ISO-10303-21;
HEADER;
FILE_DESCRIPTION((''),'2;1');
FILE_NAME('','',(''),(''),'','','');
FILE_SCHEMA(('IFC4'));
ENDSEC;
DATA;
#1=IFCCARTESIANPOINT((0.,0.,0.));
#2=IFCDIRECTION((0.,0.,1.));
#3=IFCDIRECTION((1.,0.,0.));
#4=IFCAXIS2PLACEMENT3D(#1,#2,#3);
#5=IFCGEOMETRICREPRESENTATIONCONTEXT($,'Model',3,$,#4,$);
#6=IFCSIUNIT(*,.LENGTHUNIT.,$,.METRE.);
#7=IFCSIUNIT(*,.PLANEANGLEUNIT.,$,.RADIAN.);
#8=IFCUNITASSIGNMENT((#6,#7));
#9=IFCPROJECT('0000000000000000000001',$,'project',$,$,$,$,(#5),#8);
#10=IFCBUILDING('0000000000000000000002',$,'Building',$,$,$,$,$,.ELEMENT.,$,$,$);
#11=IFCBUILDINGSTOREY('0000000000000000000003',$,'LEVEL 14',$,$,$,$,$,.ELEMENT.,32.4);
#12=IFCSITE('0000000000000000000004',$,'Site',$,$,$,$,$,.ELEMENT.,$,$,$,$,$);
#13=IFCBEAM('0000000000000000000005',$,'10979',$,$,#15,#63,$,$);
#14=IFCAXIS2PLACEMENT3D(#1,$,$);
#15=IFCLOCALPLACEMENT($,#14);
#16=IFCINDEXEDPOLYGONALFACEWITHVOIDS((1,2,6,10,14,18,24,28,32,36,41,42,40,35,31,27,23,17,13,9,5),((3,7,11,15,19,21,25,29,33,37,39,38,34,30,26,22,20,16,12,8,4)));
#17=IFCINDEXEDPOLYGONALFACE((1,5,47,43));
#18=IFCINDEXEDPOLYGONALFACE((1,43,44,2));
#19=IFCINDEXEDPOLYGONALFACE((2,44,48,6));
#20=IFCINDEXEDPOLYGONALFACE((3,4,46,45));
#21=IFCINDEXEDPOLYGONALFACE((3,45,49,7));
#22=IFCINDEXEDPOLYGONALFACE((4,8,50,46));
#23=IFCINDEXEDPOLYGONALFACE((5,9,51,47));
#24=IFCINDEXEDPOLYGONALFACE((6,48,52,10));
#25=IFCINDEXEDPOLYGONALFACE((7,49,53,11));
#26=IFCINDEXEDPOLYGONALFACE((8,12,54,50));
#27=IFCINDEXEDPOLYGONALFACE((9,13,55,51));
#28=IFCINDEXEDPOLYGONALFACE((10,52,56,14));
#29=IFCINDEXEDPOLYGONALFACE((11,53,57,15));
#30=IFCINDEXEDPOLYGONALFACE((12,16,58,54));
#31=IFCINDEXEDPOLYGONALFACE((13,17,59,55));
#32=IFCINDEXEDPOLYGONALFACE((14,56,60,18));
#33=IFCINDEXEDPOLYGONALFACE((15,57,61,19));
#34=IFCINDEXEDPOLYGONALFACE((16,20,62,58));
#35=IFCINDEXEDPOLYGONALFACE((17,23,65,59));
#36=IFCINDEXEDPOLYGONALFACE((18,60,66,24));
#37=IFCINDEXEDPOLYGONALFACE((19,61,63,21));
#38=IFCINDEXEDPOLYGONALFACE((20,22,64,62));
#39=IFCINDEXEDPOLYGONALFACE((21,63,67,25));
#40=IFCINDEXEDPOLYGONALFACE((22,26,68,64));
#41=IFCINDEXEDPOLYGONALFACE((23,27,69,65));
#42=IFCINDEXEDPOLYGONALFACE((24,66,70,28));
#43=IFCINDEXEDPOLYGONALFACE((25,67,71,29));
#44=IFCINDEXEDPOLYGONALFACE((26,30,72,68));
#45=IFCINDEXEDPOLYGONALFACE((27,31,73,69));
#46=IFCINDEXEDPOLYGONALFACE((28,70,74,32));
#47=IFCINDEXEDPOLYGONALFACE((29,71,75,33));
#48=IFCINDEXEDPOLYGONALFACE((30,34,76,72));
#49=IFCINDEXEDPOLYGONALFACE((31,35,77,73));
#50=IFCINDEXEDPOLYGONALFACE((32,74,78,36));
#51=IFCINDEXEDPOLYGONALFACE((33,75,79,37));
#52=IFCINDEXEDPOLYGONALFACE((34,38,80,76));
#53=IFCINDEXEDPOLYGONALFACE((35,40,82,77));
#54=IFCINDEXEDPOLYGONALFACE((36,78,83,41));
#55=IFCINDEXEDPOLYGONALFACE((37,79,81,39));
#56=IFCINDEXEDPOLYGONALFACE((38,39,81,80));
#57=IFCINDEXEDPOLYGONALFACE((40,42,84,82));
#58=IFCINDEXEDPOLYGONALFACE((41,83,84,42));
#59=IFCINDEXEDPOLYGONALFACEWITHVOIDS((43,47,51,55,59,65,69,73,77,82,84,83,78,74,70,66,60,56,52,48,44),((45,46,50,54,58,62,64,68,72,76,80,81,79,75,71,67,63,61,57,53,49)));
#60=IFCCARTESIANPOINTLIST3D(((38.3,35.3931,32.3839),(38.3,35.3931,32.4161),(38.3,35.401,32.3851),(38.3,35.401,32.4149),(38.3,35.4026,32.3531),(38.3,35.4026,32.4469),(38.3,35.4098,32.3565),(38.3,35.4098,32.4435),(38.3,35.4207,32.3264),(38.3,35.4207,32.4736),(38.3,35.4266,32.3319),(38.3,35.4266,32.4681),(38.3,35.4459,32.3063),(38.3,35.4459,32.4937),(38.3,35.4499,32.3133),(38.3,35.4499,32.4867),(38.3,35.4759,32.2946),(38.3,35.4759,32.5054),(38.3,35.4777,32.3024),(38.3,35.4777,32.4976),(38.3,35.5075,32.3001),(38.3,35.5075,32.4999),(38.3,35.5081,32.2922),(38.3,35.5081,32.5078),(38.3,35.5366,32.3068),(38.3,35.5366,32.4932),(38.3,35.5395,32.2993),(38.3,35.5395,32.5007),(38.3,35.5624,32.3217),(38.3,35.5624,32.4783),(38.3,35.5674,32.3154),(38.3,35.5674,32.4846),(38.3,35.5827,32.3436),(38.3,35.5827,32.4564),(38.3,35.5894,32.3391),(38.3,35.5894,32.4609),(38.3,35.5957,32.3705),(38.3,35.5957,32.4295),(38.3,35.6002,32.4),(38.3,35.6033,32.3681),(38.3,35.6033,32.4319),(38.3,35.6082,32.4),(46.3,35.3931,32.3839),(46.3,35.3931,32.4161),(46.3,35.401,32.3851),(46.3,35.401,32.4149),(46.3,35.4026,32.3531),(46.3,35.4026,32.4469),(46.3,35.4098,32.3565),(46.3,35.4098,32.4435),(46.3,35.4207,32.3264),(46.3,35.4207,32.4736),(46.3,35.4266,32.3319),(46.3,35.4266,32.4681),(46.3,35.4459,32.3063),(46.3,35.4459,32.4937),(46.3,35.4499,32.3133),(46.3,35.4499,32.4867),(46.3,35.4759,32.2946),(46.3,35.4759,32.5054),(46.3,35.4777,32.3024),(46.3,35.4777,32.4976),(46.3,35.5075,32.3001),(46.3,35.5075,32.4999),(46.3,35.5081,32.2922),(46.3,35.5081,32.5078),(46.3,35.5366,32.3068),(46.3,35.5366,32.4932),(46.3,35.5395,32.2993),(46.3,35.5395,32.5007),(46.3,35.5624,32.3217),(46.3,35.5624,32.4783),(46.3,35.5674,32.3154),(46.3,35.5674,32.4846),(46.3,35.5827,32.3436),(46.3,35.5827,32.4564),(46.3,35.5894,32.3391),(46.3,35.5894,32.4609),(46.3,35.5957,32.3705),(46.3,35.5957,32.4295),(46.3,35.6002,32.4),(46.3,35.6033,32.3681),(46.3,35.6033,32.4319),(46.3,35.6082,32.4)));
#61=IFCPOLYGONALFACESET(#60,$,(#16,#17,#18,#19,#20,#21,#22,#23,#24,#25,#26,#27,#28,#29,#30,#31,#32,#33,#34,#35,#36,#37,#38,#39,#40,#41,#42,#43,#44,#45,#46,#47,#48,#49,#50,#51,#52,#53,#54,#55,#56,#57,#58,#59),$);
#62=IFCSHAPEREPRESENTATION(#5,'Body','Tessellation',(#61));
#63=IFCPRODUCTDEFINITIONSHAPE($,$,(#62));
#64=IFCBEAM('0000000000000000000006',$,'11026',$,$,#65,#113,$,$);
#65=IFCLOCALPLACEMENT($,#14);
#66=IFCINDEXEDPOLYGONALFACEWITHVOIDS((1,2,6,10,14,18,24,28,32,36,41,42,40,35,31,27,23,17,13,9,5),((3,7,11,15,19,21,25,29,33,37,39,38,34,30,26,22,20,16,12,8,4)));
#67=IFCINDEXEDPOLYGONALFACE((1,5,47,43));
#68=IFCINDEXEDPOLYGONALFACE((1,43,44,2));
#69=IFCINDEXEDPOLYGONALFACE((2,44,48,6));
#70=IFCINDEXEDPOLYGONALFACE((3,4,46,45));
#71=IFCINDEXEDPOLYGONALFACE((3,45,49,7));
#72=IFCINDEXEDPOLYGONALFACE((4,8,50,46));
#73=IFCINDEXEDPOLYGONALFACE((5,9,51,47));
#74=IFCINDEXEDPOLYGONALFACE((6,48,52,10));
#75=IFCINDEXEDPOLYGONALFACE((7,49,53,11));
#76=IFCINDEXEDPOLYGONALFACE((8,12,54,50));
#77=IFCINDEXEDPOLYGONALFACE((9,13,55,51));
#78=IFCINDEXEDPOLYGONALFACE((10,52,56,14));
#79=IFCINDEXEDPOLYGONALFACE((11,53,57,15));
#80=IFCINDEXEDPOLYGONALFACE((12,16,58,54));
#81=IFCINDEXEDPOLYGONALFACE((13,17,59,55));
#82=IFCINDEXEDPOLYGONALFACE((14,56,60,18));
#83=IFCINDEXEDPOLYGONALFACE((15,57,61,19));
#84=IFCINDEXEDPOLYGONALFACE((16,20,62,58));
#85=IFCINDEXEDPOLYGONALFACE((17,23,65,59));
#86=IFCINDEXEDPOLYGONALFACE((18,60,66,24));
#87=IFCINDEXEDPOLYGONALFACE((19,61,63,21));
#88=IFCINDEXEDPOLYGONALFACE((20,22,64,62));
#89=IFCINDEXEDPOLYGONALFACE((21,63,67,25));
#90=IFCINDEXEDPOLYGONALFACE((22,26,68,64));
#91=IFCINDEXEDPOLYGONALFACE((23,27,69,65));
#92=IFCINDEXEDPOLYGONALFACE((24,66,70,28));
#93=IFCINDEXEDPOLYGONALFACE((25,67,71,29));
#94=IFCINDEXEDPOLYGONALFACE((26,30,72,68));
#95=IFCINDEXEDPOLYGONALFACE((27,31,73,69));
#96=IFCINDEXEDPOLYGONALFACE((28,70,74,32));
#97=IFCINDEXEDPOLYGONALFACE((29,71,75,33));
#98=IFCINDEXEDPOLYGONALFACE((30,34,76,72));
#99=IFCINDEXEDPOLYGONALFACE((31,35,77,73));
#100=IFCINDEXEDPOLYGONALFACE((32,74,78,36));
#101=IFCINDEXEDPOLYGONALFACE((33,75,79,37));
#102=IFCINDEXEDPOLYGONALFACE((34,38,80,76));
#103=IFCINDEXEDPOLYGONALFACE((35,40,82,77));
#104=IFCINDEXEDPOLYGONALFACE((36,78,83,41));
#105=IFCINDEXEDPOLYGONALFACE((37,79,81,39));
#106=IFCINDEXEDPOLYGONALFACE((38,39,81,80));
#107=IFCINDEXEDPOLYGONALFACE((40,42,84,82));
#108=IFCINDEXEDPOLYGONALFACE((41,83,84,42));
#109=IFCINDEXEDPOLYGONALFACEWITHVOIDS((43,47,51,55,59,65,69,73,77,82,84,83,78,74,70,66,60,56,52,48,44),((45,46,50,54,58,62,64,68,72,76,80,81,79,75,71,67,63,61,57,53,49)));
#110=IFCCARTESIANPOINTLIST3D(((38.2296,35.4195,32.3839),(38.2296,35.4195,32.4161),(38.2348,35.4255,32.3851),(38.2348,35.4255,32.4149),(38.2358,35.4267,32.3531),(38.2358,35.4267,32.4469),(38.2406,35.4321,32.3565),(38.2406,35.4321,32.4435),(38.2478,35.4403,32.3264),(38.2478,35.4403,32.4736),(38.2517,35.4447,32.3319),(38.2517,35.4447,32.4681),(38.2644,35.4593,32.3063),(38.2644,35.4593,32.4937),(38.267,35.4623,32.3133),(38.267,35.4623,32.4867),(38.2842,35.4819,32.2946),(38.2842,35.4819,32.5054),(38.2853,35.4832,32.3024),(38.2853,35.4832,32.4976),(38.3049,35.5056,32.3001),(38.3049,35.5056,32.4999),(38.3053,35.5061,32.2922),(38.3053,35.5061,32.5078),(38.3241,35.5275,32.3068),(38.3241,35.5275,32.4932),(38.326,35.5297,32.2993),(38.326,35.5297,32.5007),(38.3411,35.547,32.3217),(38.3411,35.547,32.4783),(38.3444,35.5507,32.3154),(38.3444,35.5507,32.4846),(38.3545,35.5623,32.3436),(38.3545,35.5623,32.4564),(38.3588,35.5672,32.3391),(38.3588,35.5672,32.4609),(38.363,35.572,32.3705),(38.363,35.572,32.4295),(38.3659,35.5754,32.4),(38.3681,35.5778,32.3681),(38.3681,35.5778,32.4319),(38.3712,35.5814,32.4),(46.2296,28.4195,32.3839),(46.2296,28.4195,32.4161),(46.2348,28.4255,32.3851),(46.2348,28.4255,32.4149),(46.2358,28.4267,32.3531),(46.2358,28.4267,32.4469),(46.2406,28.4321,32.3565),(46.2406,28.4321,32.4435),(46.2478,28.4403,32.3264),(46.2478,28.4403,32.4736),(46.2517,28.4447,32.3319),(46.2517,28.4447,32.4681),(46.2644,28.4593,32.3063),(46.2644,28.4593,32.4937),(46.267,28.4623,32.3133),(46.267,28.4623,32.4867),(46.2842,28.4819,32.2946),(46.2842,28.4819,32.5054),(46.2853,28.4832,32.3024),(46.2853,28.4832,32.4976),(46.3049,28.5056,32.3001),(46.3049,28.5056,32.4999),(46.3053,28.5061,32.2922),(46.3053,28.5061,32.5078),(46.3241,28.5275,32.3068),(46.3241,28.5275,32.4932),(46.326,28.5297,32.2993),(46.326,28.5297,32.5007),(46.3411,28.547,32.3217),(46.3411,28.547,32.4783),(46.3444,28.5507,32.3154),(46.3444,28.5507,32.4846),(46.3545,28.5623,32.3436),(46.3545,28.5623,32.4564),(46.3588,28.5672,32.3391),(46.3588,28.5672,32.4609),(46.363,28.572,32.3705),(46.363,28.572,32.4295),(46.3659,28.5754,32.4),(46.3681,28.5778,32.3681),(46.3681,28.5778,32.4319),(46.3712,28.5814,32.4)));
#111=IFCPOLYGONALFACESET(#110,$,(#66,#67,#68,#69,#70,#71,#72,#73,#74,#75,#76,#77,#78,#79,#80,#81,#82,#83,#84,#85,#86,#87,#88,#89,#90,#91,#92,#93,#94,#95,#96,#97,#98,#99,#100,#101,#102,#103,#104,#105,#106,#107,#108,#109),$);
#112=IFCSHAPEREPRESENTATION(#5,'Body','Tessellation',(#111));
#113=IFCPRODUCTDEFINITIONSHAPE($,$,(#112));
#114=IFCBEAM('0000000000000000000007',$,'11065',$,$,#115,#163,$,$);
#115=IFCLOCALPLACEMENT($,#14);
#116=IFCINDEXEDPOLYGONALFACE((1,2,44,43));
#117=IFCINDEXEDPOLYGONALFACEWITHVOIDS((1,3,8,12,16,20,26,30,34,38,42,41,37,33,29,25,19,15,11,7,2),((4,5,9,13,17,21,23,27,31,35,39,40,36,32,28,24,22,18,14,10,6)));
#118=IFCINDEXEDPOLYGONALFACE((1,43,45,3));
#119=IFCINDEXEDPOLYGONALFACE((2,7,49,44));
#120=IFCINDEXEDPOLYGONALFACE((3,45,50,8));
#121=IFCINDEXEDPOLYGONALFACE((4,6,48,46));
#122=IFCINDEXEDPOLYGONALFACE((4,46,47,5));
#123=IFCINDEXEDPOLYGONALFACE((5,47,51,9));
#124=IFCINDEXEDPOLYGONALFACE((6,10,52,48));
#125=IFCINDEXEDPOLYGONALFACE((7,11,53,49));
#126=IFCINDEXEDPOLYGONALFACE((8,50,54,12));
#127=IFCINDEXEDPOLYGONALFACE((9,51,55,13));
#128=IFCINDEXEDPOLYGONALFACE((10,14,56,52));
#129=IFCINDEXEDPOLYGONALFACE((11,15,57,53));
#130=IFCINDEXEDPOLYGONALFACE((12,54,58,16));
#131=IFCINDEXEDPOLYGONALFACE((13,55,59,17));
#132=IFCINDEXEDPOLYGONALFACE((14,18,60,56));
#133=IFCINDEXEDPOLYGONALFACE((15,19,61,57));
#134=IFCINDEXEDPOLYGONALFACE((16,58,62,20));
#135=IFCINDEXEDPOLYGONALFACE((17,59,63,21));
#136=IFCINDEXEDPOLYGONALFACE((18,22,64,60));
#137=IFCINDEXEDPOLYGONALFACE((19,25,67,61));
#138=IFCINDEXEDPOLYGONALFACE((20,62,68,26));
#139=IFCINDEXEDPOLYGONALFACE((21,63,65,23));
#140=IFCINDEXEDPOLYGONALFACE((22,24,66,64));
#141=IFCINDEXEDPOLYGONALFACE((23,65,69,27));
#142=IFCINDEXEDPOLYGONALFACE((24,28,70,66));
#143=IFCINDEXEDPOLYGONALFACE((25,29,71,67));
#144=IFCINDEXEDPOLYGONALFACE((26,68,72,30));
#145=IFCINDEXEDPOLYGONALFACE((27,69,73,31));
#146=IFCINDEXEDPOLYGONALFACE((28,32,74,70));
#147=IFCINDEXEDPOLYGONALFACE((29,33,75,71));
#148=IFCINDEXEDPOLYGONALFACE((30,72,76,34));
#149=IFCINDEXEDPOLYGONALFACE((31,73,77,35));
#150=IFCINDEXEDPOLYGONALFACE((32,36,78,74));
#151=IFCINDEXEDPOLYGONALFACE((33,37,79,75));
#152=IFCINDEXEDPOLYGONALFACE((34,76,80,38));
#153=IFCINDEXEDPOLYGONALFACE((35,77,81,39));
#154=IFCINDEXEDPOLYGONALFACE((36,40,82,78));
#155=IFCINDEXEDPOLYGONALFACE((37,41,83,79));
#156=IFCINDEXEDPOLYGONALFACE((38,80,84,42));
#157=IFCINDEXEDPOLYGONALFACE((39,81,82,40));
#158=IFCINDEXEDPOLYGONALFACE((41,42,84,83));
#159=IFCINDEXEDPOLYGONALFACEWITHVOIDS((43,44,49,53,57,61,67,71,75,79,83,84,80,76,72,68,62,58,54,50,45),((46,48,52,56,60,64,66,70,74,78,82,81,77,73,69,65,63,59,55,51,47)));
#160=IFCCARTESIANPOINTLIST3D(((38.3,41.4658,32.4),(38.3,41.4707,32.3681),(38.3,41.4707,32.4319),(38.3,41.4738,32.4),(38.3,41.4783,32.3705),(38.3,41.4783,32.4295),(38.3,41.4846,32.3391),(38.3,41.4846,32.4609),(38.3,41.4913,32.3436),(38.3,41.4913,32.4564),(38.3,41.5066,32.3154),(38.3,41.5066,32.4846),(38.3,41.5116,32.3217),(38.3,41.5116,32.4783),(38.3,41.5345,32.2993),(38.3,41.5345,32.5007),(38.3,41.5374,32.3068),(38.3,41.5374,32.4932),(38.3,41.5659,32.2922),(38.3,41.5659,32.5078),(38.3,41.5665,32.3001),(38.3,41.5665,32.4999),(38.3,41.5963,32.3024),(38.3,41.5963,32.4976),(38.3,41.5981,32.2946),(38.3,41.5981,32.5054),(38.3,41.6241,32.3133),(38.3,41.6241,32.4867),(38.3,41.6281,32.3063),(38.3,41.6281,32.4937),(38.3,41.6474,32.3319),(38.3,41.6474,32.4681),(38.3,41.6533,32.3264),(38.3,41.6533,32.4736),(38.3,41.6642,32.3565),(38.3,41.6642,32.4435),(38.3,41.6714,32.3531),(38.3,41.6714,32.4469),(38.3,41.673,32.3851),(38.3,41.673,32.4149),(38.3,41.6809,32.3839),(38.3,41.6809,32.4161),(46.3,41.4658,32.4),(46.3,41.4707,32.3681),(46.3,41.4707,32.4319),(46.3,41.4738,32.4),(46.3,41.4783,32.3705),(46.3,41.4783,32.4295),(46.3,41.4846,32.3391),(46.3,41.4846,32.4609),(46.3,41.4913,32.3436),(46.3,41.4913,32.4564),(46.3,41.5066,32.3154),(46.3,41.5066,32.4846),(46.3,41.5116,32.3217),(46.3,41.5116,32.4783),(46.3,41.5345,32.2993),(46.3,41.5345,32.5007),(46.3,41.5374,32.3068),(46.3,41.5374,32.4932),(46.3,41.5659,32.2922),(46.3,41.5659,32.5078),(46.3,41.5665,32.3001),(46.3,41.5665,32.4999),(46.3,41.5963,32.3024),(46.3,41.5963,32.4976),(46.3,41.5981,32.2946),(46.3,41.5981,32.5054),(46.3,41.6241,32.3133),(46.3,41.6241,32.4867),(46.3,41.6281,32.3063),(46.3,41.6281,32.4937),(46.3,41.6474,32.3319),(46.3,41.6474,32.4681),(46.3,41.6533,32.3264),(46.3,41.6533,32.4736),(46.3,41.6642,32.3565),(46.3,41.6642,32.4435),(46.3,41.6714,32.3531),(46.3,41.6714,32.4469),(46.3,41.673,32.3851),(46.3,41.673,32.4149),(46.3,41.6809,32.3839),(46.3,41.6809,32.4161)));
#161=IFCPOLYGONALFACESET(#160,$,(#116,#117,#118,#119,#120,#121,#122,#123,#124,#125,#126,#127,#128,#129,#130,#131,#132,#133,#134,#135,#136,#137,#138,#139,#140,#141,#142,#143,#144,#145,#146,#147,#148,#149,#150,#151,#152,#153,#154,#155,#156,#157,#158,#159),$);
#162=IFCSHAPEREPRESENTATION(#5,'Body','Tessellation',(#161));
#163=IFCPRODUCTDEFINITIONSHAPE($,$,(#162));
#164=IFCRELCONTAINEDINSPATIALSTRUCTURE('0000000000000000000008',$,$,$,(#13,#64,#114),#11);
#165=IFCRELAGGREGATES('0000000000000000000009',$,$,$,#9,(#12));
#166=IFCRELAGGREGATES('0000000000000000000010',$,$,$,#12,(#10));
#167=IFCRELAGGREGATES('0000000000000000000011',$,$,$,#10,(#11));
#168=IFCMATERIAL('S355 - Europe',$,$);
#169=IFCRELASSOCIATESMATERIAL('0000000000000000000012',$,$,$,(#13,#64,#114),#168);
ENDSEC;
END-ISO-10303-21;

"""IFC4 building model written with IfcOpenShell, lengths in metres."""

from ifc_helpers import new_model, si_unit, frame, origin_with_axes, origin_2d_with_axis, place, context, project, spatial, hollow_circle, extrude, material, material_profile, profile_set, profile_usage, element, save


model = new_model("IFC4")

# Units and contexts
model_context = context("Model", 3, world=origin_with_axes())
ifc_project = project(units=[si_unit("LENGTHUNIT", "METRE"), si_unit("PLANEANGLEUNIT", "RADIAN")], contexts=[model_context])

# Site, building, storey
site = spatial("IfcSite", under=ifc_project, Name="Site", CompositionType="ELEMENT")
building = spatial("IfcBuilding", under=site, Name="Building", CompositionType="ELEMENT")
storey = spatial("IfcBuildingStorey", under=building, Name="LEVEL 14", CompositionType="ELEMENT", Elevation=32.4)

# Shared definitions
ifc_material = material(Name="S355 - Europe")

# Beams
ifc_material_profile_1 = material_profile(ifc_material, hollow_circle(Radius=0.1081, WallThickness=0.008, at=origin_2d_with_axis()))
ifc_profile_set_1 = profile_set([ifc_material_profile_1])
ifc_profile_usage_1 = profile_usage(ifc_profile_set_1, cardinal=10)
beam_1_placement = place(None, frame((38.3, 35.5, 32.4), z_axis=(1.0, 0.0, 0.0), x_axis=(0.0, 1.0, 0.0)))
element("IfcBeam", 1, at=beam_1_placement, inside=storey, material=ifc_profile_usage_1, Name="10979", context=model_context, shape_type="SweptSolid", body=[
    extrude(hollow_circle(Radius=0.1081, WallThickness=0.008, at=origin_2d_with_axis()), origin_with_axes(), (0.0, 0.0, 1.0), 8.0),
])
ifc_material_profile_2 = material_profile(ifc_material, hollow_circle(Radius=0.1081, WallThickness=0.008, at=origin_2d_with_axis()))
ifc_profile_set_2 = profile_set([ifc_material_profile_2])
ifc_profile_usage_2 = profile_usage(ifc_profile_set_2, cardinal=10)
beam_2_placement = place(None, frame((38.3, 35.5, 32.4), z_axis=(0.752577, -0.658505, 0.0), x_axis=(0.658505, 0.752577, 0.0)))
element("IfcBeam", 2, at=beam_2_placement, inside=storey, material=ifc_profile_usage_2, Name="11026", context=model_context, shape_type="SweptSolid", body=[
    extrude(hollow_circle(Radius=0.1081, WallThickness=0.008, at=origin_2d_with_axis()), origin_with_axes(), (0.0, 0.0, 1.0), 10.6301),
])
ifc_material_profile_3 = material_profile(ifc_material, hollow_circle(Radius=0.1081, WallThickness=0.008, at=origin_2d_with_axis()))
ifc_profile_set_3 = profile_set([ifc_material_profile_3])
ifc_profile_usage_3 = profile_usage(ifc_profile_set_3, cardinal=10)
beam_3_placement = place(None, frame((46.3, 41.574, 32.4), z_axis=(-1.0, 0.0, 0.0), x_axis=(0.0, -1.0, 0.0)))
element("IfcBeam", 3, at=beam_3_placement, inside=storey, material=ifc_profile_usage_3, Name="11065", context=model_context, shape_type="SweptSolid", body=[
    extrude(hollow_circle(Radius=0.1081, WallThickness=0.008, at=origin_2d_with_axis()), origin_with_axes(), (0.0, 0.0, 1.0), 8.0),
])

save(model, "model.ifc")
